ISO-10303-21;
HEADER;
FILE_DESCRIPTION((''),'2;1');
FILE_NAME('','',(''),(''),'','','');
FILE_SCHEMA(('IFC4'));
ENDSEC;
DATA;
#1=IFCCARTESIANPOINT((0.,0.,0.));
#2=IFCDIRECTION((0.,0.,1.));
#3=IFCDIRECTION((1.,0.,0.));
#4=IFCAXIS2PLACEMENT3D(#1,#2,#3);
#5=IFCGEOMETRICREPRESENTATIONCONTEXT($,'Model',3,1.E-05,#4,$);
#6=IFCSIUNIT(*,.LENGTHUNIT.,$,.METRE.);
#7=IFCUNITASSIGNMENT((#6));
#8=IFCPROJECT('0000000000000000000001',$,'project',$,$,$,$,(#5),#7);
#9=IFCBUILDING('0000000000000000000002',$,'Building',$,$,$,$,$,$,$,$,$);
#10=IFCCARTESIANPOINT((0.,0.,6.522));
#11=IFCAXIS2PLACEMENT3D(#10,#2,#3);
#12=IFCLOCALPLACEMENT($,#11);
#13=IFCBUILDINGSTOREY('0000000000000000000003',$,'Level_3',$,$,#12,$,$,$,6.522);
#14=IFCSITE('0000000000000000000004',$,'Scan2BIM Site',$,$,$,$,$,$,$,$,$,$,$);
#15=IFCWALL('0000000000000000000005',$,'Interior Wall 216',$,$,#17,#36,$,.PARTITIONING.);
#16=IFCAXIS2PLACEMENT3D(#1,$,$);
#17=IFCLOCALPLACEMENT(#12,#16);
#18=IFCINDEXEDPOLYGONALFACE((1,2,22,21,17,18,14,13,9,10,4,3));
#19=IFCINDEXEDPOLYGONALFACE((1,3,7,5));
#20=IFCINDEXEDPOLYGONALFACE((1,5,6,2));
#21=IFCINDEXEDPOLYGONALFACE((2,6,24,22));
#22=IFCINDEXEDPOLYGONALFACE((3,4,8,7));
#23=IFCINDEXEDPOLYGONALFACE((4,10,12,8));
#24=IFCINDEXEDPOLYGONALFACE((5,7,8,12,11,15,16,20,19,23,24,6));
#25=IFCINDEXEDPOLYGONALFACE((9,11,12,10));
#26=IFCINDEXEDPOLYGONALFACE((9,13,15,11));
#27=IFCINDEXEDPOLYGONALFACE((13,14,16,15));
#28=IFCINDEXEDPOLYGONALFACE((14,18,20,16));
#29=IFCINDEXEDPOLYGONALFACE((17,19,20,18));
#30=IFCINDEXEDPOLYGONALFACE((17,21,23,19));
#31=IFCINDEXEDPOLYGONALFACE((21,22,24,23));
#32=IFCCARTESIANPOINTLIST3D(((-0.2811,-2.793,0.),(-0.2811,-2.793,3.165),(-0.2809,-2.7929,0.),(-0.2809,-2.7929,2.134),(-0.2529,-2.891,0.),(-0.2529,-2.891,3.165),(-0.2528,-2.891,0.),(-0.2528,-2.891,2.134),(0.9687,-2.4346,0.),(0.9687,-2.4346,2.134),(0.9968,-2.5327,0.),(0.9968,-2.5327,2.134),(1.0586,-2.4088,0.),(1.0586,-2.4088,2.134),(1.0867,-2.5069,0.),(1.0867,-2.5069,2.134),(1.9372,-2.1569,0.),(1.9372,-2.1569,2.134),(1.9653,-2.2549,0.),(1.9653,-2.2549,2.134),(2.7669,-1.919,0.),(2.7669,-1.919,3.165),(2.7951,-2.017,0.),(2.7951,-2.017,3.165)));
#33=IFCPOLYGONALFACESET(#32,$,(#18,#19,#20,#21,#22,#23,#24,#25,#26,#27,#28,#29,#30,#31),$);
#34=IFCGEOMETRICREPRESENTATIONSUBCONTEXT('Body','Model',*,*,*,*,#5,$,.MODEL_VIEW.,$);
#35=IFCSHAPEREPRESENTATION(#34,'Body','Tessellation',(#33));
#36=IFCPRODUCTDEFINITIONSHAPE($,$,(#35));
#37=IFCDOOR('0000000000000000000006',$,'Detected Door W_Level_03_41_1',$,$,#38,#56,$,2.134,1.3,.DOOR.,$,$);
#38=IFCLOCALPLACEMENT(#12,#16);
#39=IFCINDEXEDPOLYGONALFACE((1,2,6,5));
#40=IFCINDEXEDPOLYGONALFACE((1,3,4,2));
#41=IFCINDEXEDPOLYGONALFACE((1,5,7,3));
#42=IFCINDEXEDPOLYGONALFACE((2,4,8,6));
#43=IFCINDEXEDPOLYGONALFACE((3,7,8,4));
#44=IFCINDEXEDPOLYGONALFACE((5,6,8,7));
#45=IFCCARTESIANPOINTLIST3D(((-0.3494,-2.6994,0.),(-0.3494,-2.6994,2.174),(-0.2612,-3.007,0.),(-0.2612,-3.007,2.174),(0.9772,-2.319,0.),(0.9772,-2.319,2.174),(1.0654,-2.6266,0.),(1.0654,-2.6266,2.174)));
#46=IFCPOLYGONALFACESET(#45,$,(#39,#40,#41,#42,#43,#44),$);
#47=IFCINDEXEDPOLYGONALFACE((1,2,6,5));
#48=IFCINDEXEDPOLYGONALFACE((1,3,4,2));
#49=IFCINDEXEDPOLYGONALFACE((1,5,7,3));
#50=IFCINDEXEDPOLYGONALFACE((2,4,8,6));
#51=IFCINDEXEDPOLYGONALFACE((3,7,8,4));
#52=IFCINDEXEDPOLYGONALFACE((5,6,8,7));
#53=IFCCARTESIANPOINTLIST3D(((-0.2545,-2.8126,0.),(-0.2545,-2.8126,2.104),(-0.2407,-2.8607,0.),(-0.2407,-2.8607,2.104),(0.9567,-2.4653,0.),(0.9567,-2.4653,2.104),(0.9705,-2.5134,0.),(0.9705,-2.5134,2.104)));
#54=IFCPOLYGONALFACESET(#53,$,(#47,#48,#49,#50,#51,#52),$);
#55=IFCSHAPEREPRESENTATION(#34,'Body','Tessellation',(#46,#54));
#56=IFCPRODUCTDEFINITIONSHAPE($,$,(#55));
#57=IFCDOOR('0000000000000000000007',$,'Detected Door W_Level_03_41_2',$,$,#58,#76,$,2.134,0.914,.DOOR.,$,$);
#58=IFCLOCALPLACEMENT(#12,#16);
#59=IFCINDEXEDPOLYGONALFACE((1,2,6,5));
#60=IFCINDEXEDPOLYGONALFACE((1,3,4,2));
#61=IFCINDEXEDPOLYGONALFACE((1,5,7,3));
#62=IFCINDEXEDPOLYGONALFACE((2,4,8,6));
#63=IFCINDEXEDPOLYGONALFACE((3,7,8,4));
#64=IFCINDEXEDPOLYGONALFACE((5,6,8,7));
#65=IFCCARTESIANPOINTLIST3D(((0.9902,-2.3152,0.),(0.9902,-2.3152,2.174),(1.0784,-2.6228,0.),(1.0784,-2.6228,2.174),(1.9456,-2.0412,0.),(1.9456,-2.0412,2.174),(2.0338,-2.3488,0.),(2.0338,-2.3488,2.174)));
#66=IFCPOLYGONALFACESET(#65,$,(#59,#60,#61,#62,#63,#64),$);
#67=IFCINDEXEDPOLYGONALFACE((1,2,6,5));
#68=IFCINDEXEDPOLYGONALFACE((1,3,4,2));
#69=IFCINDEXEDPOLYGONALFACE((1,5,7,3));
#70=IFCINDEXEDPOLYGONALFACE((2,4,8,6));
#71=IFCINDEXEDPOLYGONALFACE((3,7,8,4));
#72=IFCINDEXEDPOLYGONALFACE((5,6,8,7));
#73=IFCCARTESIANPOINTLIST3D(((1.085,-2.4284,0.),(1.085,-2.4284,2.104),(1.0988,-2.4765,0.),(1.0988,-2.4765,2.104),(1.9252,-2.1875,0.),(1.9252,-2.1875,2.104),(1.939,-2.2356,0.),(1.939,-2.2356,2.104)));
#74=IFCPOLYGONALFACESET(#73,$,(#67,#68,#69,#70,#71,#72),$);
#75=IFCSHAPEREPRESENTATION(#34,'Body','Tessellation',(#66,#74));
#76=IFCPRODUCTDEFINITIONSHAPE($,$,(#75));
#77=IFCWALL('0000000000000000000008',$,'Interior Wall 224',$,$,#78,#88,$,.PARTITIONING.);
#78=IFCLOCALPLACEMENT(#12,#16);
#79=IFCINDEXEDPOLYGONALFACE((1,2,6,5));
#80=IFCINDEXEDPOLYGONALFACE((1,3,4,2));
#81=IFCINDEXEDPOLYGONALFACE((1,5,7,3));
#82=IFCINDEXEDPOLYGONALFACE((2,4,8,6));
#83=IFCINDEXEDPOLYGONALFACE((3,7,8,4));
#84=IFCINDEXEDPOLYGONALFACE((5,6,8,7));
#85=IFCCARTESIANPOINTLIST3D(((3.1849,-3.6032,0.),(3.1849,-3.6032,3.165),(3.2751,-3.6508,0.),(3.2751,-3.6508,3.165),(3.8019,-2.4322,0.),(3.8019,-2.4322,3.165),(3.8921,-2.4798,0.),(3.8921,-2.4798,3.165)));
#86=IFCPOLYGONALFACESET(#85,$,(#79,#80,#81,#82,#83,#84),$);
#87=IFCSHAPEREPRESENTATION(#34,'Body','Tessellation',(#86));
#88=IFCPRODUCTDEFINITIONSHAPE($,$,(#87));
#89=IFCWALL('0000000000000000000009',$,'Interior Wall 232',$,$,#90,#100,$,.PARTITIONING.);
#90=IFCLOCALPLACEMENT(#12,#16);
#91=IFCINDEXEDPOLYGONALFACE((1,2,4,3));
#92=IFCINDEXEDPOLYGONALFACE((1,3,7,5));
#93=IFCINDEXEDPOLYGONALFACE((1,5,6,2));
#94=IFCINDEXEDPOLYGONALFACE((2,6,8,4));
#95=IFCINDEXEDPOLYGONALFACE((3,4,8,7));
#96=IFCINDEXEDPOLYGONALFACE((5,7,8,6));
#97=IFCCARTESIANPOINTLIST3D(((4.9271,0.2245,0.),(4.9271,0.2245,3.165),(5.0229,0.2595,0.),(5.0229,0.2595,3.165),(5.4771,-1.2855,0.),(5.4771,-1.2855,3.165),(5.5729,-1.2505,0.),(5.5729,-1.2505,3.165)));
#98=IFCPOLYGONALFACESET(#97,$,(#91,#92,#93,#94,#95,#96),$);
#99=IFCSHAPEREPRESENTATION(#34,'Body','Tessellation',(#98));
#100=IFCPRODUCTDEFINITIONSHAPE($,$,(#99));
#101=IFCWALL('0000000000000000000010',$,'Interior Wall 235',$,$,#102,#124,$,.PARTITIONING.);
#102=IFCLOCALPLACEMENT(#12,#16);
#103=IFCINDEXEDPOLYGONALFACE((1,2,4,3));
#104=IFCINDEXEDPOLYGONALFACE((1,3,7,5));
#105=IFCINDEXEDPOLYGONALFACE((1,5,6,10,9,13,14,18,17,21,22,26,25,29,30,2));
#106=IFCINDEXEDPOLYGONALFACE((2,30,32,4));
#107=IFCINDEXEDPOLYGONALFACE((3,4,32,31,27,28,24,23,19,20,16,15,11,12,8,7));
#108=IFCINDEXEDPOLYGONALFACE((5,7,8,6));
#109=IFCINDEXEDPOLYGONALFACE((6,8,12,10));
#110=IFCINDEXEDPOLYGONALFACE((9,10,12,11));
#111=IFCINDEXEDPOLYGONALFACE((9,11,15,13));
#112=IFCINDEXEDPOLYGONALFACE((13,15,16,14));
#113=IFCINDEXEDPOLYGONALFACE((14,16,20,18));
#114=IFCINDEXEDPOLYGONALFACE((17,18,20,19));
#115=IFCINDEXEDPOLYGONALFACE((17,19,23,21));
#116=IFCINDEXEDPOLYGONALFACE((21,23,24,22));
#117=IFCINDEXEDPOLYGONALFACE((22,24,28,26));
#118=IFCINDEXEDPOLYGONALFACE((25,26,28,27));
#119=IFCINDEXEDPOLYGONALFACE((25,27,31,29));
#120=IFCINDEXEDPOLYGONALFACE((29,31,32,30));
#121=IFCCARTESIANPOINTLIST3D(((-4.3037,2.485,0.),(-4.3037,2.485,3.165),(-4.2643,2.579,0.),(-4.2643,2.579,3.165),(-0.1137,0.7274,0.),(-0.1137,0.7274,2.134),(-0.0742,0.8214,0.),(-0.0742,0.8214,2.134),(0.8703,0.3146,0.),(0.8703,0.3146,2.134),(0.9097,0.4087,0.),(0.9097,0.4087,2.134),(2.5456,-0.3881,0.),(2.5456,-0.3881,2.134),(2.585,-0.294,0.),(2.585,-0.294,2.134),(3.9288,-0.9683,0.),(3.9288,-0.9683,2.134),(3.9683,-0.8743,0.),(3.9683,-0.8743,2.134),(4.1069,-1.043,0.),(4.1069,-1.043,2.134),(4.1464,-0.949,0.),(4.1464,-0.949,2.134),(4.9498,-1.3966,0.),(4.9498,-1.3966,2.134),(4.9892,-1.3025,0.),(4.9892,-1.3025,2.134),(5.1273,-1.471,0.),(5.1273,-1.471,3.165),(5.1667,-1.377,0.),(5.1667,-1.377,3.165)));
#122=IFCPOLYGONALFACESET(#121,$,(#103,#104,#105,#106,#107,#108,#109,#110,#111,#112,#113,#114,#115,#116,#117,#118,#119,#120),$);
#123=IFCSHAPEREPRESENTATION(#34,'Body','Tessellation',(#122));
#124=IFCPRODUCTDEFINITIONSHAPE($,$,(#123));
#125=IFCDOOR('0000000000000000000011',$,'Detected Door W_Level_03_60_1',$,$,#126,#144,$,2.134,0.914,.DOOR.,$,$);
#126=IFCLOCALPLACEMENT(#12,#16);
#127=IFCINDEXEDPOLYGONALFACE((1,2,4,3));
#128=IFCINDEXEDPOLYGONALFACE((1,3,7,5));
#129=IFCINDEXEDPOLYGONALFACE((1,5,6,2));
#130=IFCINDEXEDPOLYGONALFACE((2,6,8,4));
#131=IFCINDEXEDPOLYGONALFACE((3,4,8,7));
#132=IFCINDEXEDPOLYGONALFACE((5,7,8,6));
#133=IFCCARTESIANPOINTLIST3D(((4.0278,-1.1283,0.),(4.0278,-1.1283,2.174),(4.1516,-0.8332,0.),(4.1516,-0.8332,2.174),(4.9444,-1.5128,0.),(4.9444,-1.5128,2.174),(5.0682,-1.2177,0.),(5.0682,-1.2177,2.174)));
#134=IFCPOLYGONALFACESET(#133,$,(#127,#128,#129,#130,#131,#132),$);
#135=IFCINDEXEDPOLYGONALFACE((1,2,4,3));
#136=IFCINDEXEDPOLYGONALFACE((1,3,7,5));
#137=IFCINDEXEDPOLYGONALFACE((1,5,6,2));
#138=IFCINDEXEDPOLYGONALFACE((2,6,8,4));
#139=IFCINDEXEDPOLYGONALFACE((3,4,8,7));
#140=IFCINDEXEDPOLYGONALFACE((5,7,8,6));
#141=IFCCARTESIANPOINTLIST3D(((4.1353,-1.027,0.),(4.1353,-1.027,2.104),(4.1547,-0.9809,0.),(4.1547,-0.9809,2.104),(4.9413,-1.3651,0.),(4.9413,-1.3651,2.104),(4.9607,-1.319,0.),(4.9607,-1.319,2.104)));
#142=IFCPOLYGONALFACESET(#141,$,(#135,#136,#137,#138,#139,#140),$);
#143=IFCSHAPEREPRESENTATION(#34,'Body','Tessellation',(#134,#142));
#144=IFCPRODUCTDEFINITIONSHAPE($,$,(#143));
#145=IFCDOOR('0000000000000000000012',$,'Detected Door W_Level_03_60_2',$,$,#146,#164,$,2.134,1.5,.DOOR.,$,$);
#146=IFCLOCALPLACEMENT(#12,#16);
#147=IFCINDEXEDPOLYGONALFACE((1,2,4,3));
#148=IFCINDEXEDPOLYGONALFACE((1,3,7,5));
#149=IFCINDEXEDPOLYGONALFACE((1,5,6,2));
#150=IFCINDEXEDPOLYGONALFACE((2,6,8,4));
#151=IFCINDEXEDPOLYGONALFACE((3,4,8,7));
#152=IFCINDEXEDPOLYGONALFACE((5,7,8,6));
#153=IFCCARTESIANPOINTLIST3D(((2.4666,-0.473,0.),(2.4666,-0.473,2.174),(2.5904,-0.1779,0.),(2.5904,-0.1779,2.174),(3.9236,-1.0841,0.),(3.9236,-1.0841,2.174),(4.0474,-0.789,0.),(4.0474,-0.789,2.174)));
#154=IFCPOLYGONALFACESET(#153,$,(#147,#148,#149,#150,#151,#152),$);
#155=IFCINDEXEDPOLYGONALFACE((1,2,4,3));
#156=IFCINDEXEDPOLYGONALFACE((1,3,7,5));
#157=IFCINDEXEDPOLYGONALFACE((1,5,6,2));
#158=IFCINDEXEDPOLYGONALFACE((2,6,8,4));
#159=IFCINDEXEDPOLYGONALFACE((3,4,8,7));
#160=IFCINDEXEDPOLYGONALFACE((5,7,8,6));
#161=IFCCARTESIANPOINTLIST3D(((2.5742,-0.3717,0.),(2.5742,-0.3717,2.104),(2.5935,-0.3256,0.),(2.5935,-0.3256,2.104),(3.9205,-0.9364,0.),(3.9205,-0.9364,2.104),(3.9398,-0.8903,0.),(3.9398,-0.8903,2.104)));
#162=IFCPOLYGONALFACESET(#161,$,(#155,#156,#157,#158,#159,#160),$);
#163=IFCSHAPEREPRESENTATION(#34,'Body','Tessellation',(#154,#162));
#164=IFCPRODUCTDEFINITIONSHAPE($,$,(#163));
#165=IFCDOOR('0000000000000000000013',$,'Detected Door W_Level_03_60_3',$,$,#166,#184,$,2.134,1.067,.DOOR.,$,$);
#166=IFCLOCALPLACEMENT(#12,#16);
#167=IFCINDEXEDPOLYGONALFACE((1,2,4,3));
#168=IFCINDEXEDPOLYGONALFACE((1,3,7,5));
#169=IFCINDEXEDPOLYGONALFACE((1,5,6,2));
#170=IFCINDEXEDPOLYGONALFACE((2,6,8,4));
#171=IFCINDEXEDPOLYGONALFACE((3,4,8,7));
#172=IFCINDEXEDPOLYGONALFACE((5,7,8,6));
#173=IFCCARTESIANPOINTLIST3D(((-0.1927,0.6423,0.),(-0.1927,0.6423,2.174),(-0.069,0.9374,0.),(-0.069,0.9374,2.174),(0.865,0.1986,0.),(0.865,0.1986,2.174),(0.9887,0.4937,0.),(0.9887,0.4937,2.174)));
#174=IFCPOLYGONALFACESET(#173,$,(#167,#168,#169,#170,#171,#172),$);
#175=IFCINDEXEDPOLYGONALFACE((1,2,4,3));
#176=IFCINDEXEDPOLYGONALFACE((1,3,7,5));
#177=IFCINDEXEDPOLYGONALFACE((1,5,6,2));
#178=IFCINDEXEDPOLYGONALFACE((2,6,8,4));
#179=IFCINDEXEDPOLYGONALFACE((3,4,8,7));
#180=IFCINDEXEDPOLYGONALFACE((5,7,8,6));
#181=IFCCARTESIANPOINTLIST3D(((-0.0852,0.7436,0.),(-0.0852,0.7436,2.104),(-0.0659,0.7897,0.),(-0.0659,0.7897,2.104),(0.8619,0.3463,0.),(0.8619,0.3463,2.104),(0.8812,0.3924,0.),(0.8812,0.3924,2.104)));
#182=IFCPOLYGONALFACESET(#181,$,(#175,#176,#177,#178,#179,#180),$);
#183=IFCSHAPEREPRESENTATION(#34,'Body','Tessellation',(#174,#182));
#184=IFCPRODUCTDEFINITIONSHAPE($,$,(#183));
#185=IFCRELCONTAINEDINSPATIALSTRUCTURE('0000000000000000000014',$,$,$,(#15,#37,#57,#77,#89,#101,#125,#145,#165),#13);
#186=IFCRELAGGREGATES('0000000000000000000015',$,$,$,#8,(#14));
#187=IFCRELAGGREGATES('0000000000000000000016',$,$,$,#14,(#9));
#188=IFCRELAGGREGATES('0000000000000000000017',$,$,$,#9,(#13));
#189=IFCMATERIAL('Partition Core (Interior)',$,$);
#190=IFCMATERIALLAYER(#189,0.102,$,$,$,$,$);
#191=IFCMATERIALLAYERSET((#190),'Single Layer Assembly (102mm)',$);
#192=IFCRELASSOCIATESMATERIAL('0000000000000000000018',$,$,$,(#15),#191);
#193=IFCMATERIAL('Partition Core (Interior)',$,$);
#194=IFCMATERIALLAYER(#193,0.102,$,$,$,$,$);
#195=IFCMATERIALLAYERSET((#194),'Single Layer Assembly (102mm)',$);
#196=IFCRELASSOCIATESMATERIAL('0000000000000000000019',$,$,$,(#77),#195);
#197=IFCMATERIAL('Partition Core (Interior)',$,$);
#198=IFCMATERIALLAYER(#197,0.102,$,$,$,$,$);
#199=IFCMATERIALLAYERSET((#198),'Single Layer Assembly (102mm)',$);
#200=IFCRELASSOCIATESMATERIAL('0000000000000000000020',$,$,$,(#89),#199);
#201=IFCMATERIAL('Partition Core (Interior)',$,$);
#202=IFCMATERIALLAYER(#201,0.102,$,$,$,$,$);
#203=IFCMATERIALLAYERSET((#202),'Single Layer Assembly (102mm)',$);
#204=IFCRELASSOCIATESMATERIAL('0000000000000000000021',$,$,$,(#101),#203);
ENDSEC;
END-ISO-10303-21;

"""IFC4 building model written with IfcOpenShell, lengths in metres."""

from ifc_helpers import new_model, si_unit, frame, origin, origin_with_axes, place, context, subcontext, project, spatial, rectangle, extrude, material, layer, layer_set, element, fill, save


model = new_model("IFC4")

# Units and contexts
model_context = context("Model", 3, precision=1e-05, world=origin_with_axes())
body_context = subcontext(model_context, "Body", "Model", "MODEL_VIEW")
ifc_project = project(units=[si_unit("LENGTHUNIT", "METRE")], contexts=[model_context])

# Site, building, storey
site = spatial("IfcSite", under=ifc_project, Name="Scan2BIM Site")
building = spatial("IfcBuilding", under=site, Name="Building")
storey_placement = place(None, frame((0.0, 0.0, 6.522), z_axis=(0.0, 0.0, 1.0), x_axis=(1.0, 0.0, 0.0)))
storey = spatial("IfcBuildingStorey", under=building, at=storey_placement, Name="Level_3", Elevation=6.522)

# Wall, openings, doors
ifc_material_1 = material(Name="Partition Core (Interior)")
ifc_layer_1 = layer(ifc_material_1, 0.102)
ifc_layer_set_1 = layer_set([ifc_layer_1], Name="Single Layer Assembly (102mm)")
wall_1_placement = place(storey_placement, frame((1.257, -2.405, 0.0), z_axis=(0.0, 0.0, 1.0), x_axis=(0.961262, 0.275637, 0.0)))
wall_1 = element("IfcWall", 1, at=wall_1_placement, inside=storey, material=ifc_layer_set_1, Name="Interior Wall 216", PredefinedType="PARTITIONING", context=body_context, shape_type="SweptSolid", body=[
    extrude(rectangle(XDim=3.1708, YDim=0.102), origin(), (0.0, 0.0, 1.0), 3.165),
])
opening_1_placement = place(None, frame((0.358, -2.663, 6.522), z_axis=(0.0, 0.0, 1.0), x_axis=(0.961262, 0.275637, 0.0)))
opening_1 = element("IfcOpeningElement", 2, at=opening_1_placement, cuts=wall_1, PredefinedType="OPENING", context=body_context, shape_type="SweptSolid", body=[
    extrude(rectangle(XDim=1.3, YDim=0.202), origin(), (0.0, 0.0, 1.0), 2.134),
])
opening_2_placement = place(None, frame((1.512, -2.332, 6.522), z_axis=(0.0, 0.0, 1.0), x_axis=(0.961262, 0.275637, 0.0)))
opening_2 = element("IfcOpeningElement", 3, at=opening_2_placement, cuts=wall_1, PredefinedType="OPENING", context=body_context, shape_type="SweptSolid", body=[
    extrude(rectangle(XDim=0.914, YDim=0.202), origin(), (0.0, 0.0, 1.0), 2.134),
])
door_1_placement = place(opening_1_placement, frame((0.0, 0.0, 0.0), z_axis=(0.0, 0.0, 1.0), x_axis=(1.0, 0.0, 0.0)))
door_1 = element("IfcDoor", 4, at=door_1_placement, inside=storey, Name="Detected Door W_Level_03_41_1", OverallHeight=2.134, OverallWidth=1.3, PredefinedType="DOOR", context=body_context, shape_type="SweptSolid", body=[
    extrude(rectangle(XDim=1.38, YDim=0.32), origin(), (0.0, 0.0, 1.0), 2.174),
    extrude(rectangle(XDim=1.26, YDim=0.05), origin(), (0.0, 0.0, 1.0), 2.104),
])
fill(opening_1, door_1)
door_2_placement = place(opening_2_placement, frame((0.0, 0.0, 0.0), z_axis=(0.0, 0.0, 1.0), x_axis=(1.0, 0.0, 0.0)))
door_2 = element("IfcDoor", 5, at=door_2_placement, inside=storey, Name="Detected Door W_Level_03_41_2", OverallHeight=2.134, OverallWidth=0.914, PredefinedType="DOOR", context=body_context, shape_type="SweptSolid", body=[
    extrude(rectangle(XDim=0.994, YDim=0.32), origin(), (0.0, 0.0, 1.0), 2.174),
    extrude(rectangle(XDim=0.874, YDim=0.05), origin(), (0.0, 0.0, 1.0), 2.104),
])
fill(opening_2, door_2)

# Walls
ifc_material_2 = material(Name="Partition Core (Interior)")
ifc_layer_2 = layer(ifc_material_2, 0.102)
ifc_layer_set_2 = layer_set([ifc_layer_2], Name="Single Layer Assembly (102mm)")
wall_2_placement = place(storey_placement, frame((3.5385, -3.0415, 0.0), z_axis=(0.0, 0.0, 1.0), x_axis=(0.466151, 0.884705, 0.0)))
element("IfcWall", 6, at=wall_2_placement, inside=storey, material=ifc_layer_set_2, Name="Interior Wall 224", PredefinedType="PARTITIONING", context=body_context, shape_type="SweptSolid", body=[
    extrude(rectangle(XDim=1.3236, YDim=0.102), origin(), (0.0, 0.0, 1.0), 3.165),
])
ifc_material_3 = material(Name="Partition Core (Interior)")
ifc_layer_3 = layer(ifc_material_3, 0.102)
ifc_layer_set_3 = layer_set([ifc_layer_3], Name="Single Layer Assembly (102mm)")
wall_3_placement = place(storey_placement, frame((5.25, -0.513, 0.0), z_axis=(0.0, 0.0, 1.0), x_axis=(0.342243, -0.939612, 0.0)))
element("IfcWall", 7, at=wall_3_placement, inside=storey, material=ifc_layer_set_3, Name="Interior Wall 232", PredefinedType="PARTITIONING", context=body_context, shape_type="SweptSolid", body=[
    extrude(rectangle(XDim=1.607, YDim=0.102), origin(), (0.0, 0.0, 1.0), 3.165),
])

# Wall, openings, doors
ifc_material_4 = material(Name="Partition Core (Interior)")
ifc_layer_4 = layer(ifc_material_4, 0.102)
ifc_layer_set_4 = layer_set([ifc_layer_4], Name="Single Layer Assembly (102mm)")
wall_4_placement = place(storey_placement, frame((0.4315, 0.554, 0.0), z_axis=(0.0, 0.0, 1.0), x_axis=(-0.922157, 0.386815, 0.0)))
wall_4 = element("IfcWall", 8, at=wall_4_placement, inside=storey, material=ifc_layer_set_4, Name="Interior Wall 235", PredefinedType="PARTITIONING", context=body_context, shape_type="SweptSolid", body=[
    extrude(rectangle(XDim=10.2271, YDim=0.102), origin(), (0.0, 0.0, 1.0), 3.165),
])
opening_3_placement = place(None, frame((4.548, -1.173, 6.522), z_axis=(0.0, 0.0, 1.0), x_axis=(-0.922157, 0.386815, 0.0)))
opening_3 = element("IfcOpeningElement", 9, at=opening_3_placement, cuts=wall_4, PredefinedType="OPENING", context=body_context, shape_type="SweptSolid", body=[
    extrude(rectangle(XDim=0.914, YDim=0.202), origin(), (0.0, 0.0, 1.0), 2.134),
])
opening_4_placement = place(None, frame((3.257, -0.631, 6.522), z_axis=(0.0, 0.0, 1.0), x_axis=(-0.922157, 0.386815, 0.0)))
opening_4 = element("IfcOpeningElement", 10, at=opening_4_placement, cuts=wall_4, PredefinedType="OPENING", context=body_context, shape_type="SweptSolid", body=[
    extrude(rectangle(XDim=1.5, YDim=0.202), origin(), (0.0, 0.0, 1.0), 2.134),
])
opening_5_placement = place(None, frame((0.398, 0.568, 6.522), z_axis=(0.0, 0.0, 1.0), x_axis=(-0.922157, 0.386815, 0.0)))
opening_5 = element("IfcOpeningElement", 11, at=opening_5_placement, cuts=wall_4, PredefinedType="OPENING", context=body_context, shape_type="SweptSolid", body=[
    extrude(rectangle(XDim=1.067, YDim=0.202), origin(), (0.0, 0.0, 1.0), 2.134),
])
door_3_placement = place(opening_3_placement, frame((0.0, 0.0, 0.0), z_axis=(0.0, 0.0, 1.0), x_axis=(1.0, 0.0, 0.0)))
door_3 = element("IfcDoor", 12, at=door_3_placement, inside=storey, Name="Detected Door W_Level_03_60_1", OverallHeight=2.134, OverallWidth=0.914, PredefinedType="DOOR", context=body_context, shape_type="SweptSolid", body=[
    extrude(rectangle(XDim=0.994, YDim=0.32), origin(), (0.0, 0.0, 1.0), 2.174),
    extrude(rectangle(XDim=0.874, YDim=0.05), origin(), (0.0, 0.0, 1.0), 2.104),
])
fill(opening_3, door_3)
door_4_placement = place(opening_4_placement, frame((0.0, 0.0, 0.0), z_axis=(0.0, 0.0, 1.0), x_axis=(1.0, 0.0, 0.0)))
door_4 = element("IfcDoor", 13, at=door_4_placement, inside=storey, Name="Detected Door W_Level_03_60_2", OverallHeight=2.134, OverallWidth=1.5, PredefinedType="DOOR", context=body_context, shape_type="SweptSolid", body=[
    extrude(rectangle(XDim=1.58, YDim=0.32), origin(), (0.0, 0.0, 1.0), 2.174),
    extrude(rectangle(XDim=1.46, YDim=0.05), origin(), (0.0, 0.0, 1.0), 2.104),
])
fill(opening_4, door_4)
door_5_placement = place(opening_5_placement, frame((0.0, 0.0, 0.0), z_axis=(0.0, 0.0, 1.0), x_axis=(1.0, 0.0, 0.0)))
door_5 = element("IfcDoor", 14, at=door_5_placement, inside=storey, Name="Detected Door W_Level_03_60_3", OverallHeight=2.134, OverallWidth=1.067, PredefinedType="DOOR", context=body_context, shape_type="SweptSolid", body=[
    extrude(rectangle(XDim=1.147, YDim=0.32), origin(), (0.0, 0.0, 1.0), 2.174),
    extrude(rectangle(XDim=1.027, YDim=0.05), origin(), (0.0, 0.0, 1.0), 2.104),
])
fill(opening_5, door_5)

save(model, "model.ifc")
